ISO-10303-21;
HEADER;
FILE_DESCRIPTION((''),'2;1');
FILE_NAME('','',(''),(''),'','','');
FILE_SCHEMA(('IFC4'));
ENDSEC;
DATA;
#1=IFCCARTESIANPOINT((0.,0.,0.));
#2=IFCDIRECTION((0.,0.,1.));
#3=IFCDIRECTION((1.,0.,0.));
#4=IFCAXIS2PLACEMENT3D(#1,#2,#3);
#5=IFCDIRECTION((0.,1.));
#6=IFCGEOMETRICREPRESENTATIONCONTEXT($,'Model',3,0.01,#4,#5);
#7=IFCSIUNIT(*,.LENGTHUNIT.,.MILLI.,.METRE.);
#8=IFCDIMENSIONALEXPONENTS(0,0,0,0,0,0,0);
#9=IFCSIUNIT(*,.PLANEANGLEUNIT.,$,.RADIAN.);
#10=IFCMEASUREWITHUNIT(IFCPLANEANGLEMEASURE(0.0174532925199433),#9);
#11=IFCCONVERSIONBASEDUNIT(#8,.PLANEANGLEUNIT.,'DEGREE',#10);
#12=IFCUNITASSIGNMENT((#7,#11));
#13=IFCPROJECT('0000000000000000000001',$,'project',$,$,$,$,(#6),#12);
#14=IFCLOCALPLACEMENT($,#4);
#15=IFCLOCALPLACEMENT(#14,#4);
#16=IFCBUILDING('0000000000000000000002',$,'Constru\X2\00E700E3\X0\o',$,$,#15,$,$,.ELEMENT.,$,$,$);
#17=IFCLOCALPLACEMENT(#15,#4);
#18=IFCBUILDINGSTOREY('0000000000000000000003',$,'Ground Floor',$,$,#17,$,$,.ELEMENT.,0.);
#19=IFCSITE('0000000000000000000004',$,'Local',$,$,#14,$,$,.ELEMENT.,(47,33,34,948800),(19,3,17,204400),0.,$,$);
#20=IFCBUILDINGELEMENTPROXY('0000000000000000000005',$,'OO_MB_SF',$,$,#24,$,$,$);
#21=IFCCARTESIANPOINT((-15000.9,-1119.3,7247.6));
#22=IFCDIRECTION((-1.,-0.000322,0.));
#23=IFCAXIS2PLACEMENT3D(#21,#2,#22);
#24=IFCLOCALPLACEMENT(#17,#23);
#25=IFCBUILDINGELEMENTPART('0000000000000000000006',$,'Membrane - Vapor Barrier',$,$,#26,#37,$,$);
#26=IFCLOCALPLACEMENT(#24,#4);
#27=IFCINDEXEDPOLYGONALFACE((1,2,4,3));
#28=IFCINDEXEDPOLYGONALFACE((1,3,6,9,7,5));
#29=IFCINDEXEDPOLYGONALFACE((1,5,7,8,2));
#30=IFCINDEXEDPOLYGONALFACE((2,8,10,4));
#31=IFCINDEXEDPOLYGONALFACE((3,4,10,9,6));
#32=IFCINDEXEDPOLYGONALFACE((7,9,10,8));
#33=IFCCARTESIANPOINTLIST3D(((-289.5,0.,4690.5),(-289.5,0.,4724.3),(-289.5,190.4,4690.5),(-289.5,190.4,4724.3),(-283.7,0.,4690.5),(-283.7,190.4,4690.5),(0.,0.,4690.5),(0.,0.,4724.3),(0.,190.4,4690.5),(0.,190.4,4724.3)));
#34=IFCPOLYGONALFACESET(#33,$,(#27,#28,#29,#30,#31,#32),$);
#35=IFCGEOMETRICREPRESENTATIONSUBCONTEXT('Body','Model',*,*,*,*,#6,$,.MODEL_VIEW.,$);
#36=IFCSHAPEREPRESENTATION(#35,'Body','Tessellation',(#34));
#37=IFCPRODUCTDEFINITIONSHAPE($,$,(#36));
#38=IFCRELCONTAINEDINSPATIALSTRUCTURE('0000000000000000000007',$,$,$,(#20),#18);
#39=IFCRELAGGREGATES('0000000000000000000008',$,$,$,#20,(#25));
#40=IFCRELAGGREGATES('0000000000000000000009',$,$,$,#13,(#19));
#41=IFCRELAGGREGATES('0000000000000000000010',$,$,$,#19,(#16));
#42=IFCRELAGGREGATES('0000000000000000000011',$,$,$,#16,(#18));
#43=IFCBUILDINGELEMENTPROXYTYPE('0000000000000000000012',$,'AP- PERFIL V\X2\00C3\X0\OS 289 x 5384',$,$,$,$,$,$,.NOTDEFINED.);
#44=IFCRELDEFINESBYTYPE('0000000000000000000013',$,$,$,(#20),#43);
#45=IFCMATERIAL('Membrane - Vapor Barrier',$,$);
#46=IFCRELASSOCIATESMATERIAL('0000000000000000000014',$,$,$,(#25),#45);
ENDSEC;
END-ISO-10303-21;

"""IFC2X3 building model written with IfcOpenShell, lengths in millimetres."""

from ifc_helpers import new_model, entity, si_unit, converted_unit, direction, frame, origin_with_axes, place, context, subcontext, project, spatial, polyline, outline, extrude, material, type_object, element, aggregate, save


model = new_model("IFC2X3")

# Units and contexts
model_context = context("Model", 3, precision=0.01, world=origin_with_axes(), true_north=direction((0.0, 1.0)))
body_context = subcontext(model_context, "Body", "Model", "MODEL_VIEW")
ifc_project = project(units=[si_unit("LENGTHUNIT", "METRE", prefix="MILLI"), converted_unit("PLANEANGLEUNIT", "DEGREE", entity("IfcPlaneAngleMeasure", 0.0174532925199433), si_unit("PLANEANGLEUNIT", "RADIAN"), dimensions=[0, 0, 0, 0, 0, 0, 0])], contexts=[model_context])

# Site, building, storey
site_placement = place(None, origin_with_axes())
site = spatial("IfcSite", under=ifc_project, at=site_placement, Name="Local", CompositionType="ELEMENT", RefLatitude=(47, 33, 34, 948800), RefLongitude=(19, 3, 17, 204400), RefElevation=0.0)
building_placement = place(site_placement, origin_with_axes())
building = spatial("IfcBuilding", under=site, at=building_placement, Name="Construção", CompositionType="ELEMENT")
storey_placement = place(building_placement, origin_with_axes())
storey = spatial("IfcBuildingStorey", under=building, at=storey_placement, Name="Ground Floor", CompositionType="ELEMENT", Elevation=0.0)

# Building element proxy
building_element_proxy_type = type_object("IfcBuildingElementProxyType", Name="AP- PERFIL VÃOS 289 x 5384", PredefinedType="NOTDEFINED")
ifc_material = material(Name="Membrane - Vapor Barrier")
proxy_1_placement = place(storey_placement, frame((-15000.9, -1119.3, 7247.6), z_axis=(0.0, 0.0, 1.0), x_axis=(-1.0, -0.000322, 0.0)))
proxy_1 = element("IfcBuildingElementProxy", 1, at=proxy_1_placement, inside=storey, type_object=building_element_proxy_type, Name="OO_MB_SF")

# Building element part
building_element_part_1_placement = place(proxy_1_placement, origin_with_axes())
building_element_part_1 = element("IfcBuildingElementPart", 2, at=building_element_part_1_placement, material=ifc_material, Name="Membrane - Vapor Barrier", context=body_context, shape_type="SweptSolid", body=[
    extrude(outline(polyline([(0.0, 4690.5), (283.7, 4690.5), (289.5, 4690.5), (289.5, 4724.3), (0.0, 4724.3), (0.0, 4690.5)])), frame((0.0, 190.4, 0.0), z_axis=(0.0, 1.0, 0.0), x_axis=(-1.0, 0.0, 0.0)), (0.0, 0.0, -1.0), 190.4),
])
aggregate(proxy_1, [building_element_part_1])

save(model, "model.ifc")
